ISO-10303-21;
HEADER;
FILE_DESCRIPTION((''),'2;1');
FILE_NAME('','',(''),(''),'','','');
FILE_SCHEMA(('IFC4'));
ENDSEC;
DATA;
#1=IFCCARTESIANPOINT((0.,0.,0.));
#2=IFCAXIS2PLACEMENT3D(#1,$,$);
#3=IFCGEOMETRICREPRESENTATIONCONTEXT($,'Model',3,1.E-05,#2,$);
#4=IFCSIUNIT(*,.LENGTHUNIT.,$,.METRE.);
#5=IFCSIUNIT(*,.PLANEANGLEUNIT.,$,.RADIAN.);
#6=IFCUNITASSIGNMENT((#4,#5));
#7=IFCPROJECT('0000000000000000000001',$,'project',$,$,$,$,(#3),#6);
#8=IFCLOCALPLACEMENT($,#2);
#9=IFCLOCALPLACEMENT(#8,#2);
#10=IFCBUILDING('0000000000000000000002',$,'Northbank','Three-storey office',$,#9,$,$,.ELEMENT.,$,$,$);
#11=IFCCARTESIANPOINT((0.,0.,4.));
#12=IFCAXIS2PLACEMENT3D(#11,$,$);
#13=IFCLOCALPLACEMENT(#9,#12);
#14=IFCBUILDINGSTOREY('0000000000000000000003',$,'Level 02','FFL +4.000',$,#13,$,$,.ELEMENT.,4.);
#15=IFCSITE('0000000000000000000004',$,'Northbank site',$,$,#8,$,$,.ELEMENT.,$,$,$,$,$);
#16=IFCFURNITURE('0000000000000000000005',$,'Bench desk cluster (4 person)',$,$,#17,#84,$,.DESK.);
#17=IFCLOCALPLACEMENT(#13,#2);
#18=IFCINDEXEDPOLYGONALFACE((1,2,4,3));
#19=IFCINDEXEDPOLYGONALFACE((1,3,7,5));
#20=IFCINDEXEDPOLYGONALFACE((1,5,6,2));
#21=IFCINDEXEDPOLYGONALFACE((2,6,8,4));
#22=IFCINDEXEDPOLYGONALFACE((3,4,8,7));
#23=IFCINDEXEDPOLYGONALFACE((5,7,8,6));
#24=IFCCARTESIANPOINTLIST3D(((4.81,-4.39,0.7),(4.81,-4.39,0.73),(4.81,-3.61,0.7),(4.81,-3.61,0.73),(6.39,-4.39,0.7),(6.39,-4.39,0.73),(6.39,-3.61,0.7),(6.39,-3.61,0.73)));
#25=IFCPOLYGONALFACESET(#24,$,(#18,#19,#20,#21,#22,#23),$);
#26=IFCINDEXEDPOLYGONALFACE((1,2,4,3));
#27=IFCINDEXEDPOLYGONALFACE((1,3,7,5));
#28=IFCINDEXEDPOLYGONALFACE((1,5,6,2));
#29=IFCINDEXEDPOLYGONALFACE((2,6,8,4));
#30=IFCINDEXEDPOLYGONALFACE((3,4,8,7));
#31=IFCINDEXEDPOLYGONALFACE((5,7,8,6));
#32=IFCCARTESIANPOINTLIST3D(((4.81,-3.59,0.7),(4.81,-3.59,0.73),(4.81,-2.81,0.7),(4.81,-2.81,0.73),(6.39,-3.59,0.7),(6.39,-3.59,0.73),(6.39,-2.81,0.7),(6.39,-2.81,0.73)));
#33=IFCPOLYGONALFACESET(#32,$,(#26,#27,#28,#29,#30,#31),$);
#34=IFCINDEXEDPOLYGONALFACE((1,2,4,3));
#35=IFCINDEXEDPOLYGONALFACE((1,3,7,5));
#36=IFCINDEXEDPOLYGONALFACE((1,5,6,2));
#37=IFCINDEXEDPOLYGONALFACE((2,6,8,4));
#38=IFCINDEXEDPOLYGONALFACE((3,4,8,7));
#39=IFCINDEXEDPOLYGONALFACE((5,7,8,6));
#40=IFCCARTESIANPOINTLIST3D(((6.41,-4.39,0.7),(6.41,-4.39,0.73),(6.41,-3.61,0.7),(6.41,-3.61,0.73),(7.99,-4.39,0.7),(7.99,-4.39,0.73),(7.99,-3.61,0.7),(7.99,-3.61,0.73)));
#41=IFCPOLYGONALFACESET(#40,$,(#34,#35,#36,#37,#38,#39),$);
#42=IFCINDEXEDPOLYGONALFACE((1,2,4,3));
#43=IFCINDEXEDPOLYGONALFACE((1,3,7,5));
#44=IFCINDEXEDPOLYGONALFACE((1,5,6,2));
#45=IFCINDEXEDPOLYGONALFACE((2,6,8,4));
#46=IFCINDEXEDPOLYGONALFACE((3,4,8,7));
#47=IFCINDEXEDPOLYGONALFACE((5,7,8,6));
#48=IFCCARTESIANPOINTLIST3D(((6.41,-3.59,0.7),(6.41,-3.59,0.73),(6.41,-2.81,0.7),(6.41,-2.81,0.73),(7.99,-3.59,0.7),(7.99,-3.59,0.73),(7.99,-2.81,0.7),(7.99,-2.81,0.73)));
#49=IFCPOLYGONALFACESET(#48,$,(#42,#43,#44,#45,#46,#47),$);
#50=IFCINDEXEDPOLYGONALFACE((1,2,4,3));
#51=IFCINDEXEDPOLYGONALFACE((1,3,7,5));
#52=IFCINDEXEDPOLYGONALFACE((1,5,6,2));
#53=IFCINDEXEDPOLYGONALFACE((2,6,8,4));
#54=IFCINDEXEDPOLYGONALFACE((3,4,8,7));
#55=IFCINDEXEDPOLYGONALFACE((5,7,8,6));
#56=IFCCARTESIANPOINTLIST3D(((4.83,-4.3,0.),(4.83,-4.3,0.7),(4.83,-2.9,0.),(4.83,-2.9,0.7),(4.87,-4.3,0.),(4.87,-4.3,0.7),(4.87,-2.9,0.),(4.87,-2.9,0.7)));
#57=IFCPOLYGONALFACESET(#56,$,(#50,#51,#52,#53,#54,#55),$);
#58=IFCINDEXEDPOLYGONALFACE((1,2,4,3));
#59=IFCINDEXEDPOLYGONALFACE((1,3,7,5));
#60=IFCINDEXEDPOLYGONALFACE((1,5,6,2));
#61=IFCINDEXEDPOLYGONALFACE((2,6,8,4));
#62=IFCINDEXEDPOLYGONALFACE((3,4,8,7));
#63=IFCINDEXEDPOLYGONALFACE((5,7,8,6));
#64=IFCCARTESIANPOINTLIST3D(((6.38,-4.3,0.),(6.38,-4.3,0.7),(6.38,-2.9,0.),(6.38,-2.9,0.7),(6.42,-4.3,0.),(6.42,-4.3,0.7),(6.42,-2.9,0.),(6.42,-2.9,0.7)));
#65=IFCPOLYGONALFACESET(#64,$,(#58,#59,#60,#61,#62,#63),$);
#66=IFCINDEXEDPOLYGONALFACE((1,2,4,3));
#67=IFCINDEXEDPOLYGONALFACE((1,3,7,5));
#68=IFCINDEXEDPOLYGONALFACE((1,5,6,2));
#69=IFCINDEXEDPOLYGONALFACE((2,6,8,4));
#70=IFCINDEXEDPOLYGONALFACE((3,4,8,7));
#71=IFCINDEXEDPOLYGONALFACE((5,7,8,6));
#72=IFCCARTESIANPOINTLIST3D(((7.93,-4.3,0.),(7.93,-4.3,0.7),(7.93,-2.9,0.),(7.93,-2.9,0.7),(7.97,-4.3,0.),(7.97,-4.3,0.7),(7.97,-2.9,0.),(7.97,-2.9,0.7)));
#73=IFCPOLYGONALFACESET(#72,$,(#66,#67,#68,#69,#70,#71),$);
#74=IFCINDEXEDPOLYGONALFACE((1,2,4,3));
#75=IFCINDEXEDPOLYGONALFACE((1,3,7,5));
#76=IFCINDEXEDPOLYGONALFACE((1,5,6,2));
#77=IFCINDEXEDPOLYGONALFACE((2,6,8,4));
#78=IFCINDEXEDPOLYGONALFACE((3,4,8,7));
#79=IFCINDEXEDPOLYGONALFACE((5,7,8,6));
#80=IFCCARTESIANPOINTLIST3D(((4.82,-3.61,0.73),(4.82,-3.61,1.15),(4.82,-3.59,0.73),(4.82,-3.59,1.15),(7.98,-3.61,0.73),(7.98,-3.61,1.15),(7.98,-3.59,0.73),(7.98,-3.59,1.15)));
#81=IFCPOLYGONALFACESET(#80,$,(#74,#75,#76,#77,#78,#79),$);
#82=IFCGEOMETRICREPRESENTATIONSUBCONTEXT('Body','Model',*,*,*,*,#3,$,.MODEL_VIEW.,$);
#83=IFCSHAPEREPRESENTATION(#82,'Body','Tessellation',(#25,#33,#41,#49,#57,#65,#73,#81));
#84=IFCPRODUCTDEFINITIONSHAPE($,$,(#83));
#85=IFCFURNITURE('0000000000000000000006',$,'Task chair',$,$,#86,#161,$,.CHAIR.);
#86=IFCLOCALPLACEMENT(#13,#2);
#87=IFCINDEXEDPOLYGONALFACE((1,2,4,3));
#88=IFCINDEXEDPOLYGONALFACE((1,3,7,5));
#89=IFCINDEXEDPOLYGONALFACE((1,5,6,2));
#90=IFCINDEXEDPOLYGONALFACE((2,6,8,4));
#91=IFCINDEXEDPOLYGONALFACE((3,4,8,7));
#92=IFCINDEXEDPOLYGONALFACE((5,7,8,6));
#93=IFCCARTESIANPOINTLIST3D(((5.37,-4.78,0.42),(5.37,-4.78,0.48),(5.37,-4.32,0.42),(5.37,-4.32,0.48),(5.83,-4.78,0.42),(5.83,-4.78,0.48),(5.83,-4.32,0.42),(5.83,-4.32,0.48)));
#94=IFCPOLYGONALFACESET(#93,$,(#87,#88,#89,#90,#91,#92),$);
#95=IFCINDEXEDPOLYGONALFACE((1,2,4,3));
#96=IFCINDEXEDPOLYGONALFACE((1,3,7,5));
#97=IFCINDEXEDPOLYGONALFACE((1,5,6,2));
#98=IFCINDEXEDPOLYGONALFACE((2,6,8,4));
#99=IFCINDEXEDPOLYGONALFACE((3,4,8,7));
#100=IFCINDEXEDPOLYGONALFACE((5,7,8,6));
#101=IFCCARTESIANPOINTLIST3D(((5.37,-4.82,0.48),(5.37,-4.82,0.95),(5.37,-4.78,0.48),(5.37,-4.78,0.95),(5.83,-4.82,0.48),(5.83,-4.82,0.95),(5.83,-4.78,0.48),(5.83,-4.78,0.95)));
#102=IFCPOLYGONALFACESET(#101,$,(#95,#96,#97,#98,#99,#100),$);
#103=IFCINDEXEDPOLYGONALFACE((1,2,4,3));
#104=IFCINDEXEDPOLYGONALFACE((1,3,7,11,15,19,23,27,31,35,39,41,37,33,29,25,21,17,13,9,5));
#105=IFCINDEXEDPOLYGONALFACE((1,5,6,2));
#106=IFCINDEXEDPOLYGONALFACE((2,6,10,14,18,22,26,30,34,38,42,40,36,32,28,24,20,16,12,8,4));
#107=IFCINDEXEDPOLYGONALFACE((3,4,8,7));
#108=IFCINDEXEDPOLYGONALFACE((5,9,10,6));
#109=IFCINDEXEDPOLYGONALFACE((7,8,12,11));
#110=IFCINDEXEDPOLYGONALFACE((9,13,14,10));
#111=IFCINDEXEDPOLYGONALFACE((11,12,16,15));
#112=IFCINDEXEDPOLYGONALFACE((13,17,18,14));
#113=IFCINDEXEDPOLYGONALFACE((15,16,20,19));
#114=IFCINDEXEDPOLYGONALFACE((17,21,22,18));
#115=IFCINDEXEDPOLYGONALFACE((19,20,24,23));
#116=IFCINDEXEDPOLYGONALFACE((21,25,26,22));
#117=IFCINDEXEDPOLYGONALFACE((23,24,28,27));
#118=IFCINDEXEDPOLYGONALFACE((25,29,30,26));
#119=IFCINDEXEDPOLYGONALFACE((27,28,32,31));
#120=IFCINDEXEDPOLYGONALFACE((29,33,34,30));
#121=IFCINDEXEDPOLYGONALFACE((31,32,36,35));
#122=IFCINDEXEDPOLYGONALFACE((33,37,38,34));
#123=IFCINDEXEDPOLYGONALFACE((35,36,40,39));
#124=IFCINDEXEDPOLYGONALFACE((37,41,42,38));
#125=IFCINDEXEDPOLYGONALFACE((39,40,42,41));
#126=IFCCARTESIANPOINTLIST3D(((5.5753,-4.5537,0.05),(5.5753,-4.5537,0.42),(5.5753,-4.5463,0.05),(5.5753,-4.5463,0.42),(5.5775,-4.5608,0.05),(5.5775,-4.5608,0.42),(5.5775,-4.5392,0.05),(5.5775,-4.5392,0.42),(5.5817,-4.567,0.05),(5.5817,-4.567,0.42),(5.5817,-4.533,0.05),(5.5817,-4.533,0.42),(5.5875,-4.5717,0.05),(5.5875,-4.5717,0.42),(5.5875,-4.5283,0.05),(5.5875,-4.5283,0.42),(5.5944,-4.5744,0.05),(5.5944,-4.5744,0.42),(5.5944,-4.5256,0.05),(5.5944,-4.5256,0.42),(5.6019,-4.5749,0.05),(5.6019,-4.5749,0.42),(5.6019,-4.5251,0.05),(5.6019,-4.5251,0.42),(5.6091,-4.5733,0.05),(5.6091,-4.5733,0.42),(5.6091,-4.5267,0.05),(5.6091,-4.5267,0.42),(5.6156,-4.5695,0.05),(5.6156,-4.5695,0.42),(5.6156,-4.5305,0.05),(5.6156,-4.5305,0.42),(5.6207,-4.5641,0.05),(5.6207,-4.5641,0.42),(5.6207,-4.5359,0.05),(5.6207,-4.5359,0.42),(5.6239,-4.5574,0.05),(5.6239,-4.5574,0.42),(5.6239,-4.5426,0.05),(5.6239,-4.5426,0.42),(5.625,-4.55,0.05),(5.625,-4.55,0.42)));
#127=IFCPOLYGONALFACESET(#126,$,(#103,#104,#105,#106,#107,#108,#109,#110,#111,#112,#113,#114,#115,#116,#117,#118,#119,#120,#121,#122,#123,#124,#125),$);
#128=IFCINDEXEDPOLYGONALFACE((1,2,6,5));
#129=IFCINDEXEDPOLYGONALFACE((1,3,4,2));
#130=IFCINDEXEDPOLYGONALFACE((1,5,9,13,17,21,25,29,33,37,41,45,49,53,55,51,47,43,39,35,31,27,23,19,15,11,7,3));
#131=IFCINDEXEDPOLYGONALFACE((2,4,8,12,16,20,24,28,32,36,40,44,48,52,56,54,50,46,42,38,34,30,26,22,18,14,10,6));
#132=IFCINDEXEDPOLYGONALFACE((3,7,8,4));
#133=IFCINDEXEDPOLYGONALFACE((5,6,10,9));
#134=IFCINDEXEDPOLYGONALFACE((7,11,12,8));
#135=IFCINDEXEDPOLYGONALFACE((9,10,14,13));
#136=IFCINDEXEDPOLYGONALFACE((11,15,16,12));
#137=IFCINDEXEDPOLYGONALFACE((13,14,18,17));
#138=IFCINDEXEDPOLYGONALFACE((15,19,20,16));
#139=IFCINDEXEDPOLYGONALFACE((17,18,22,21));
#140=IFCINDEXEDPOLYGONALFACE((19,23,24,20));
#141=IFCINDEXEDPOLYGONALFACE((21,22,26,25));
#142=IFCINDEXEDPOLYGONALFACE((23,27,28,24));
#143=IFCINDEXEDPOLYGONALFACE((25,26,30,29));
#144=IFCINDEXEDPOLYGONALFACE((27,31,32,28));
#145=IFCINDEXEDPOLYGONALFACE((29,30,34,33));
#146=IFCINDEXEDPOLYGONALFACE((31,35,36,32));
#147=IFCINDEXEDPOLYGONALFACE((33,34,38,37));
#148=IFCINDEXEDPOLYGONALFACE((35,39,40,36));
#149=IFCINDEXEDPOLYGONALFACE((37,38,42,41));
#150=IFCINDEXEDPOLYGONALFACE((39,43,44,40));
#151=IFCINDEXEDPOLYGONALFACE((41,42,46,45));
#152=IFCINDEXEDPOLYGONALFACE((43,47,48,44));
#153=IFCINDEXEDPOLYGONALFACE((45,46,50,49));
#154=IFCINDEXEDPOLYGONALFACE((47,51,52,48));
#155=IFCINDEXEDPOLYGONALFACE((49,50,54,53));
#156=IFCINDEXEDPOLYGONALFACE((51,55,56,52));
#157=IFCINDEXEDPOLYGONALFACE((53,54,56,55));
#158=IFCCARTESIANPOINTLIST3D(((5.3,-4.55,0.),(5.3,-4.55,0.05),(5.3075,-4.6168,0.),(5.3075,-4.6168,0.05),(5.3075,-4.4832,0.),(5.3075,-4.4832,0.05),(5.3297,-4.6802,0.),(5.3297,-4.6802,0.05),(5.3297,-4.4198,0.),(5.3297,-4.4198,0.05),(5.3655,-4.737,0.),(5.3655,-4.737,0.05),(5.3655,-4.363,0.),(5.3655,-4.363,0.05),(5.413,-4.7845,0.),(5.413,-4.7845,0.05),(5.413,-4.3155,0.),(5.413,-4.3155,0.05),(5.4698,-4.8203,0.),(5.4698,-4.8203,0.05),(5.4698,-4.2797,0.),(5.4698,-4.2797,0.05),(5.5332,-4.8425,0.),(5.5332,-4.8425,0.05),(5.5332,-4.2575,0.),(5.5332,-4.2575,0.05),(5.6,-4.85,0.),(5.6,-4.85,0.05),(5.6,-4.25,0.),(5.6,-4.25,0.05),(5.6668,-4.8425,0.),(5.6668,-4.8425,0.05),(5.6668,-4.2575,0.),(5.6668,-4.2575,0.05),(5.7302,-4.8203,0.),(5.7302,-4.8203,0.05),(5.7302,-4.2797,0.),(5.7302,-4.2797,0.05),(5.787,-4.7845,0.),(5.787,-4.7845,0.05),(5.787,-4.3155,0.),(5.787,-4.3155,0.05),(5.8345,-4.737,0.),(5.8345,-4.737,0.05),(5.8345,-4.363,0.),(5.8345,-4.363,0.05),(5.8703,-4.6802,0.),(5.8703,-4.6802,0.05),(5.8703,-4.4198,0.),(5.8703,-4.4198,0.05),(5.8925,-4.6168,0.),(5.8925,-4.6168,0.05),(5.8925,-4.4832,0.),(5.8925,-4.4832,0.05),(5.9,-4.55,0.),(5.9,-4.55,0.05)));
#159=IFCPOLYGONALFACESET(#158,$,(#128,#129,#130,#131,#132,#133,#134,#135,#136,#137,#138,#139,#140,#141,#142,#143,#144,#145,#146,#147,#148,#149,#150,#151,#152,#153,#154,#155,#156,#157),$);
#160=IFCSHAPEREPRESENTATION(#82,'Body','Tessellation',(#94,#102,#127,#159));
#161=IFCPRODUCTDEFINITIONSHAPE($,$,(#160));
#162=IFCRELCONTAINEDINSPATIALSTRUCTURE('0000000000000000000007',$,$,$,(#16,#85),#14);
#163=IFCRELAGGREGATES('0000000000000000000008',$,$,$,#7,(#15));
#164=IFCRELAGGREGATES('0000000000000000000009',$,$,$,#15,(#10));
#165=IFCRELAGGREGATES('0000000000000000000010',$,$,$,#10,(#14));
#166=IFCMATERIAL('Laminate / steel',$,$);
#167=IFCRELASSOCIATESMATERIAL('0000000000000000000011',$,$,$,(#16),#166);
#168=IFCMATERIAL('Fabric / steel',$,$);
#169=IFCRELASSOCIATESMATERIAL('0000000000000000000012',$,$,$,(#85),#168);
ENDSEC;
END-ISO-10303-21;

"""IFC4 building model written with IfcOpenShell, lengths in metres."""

from ifc_helpers import new_model, si_unit, frame, origin, place, context, subcontext, project, spatial, rectangle, circle, extrude, material, element, save


model = new_model("IFC4")

# Units and contexts
model_context = context("Model", 3, precision=1e-05, world=origin())
body_context = subcontext(model_context, "Body", "Model", "MODEL_VIEW")
ifc_project = project(units=[si_unit("LENGTHUNIT", "METRE"), si_unit("PLANEANGLEUNIT", "RADIAN")], contexts=[model_context])

# Site, building, storey
site_placement = place(None, origin())
site = spatial("IfcSite", under=ifc_project, at=site_placement, Name="Northbank site", CompositionType="ELEMENT")
building_placement = place(site_placement, origin())
building = spatial("IfcBuilding", under=site, at=building_placement, Name="Northbank", Description="Three-storey office", CompositionType="ELEMENT")
storey_placement = place(building_placement, frame((0.0, 0.0, 4.0)))
storey = spatial("IfcBuildingStorey", under=building, at=storey_placement, Name="Level 02", Description="FFL +4.000", CompositionType="ELEMENT", Elevation=4.0)

# Furniture
ifc_material_1 = material(Name="Fabric / steel")
ifc_material_2 = material(Name="Laminate / steel")
furniture_1_placement = place(storey_placement, frame((0.0, 0.0, -4.0)))
element("IfcFurniture", 1, at=furniture_1_placement, inside=storey, material=ifc_material_2, Name="Bench desk cluster (4 person)", PredefinedType="DESK", context=body_context, shape_type="SweptSolid", body=[
    extrude(rectangle(XDim=1.58, YDim=0.78), frame((5.6, -4.0, 4.7)), (0.0, 0.0, 1.0), 0.03),
    extrude(rectangle(XDim=1.58, YDim=0.78), frame((5.6, -3.2, 4.7)), (0.0, 0.0, 1.0), 0.03),
    extrude(rectangle(XDim=1.58, YDim=0.78), frame((7.2, -4.0, 4.7)), (0.0, 0.0, 1.0), 0.03),
    extrude(rectangle(XDim=1.58, YDim=0.78), frame((7.2, -3.2, 4.7)), (0.0, 0.0, 1.0), 0.03),
    extrude(rectangle(XDim=0.04, YDim=1.4), frame((4.85, -3.6, 4.0)), (0.0, 0.0, 1.0), 0.7),
    extrude(rectangle(XDim=0.04, YDim=1.4), frame((6.4, -3.6, 4.0)), (0.0, 0.0, 1.0), 0.7),
    extrude(rectangle(XDim=0.04, YDim=1.4), frame((7.95, -3.6, 4.0)), (0.0, 0.0, 1.0), 0.7),
    extrude(rectangle(XDim=3.16, YDim=0.02), frame((6.4, -3.6, 4.73)), (0.0, 0.0, 1.0), 0.42),
])
furniture_2_placement = place(storey_placement, frame((0.0, 0.0, -4.0)))
element("IfcFurniture", 2, at=furniture_2_placement, inside=storey, material=ifc_material_1, Name="Task chair", PredefinedType="CHAIR", context=body_context, shape_type="SweptSolid", body=[
    extrude(rectangle(XDim=0.46, YDim=0.46), frame((5.6, -4.55, 4.42)), (0.0, 0.0, 1.0), 0.06),
    extrude(rectangle(XDim=0.46, YDim=0.04), frame((5.6, -4.8, 4.48)), (0.0, 0.0, 1.0), 0.47),
    extrude(circle(Radius=0.025), frame((5.6, -4.55, 4.05), z_axis=(0.0, 0.0, 1.0), x_axis=(1.0, 0.0, 0.0)), (0.0, 0.0, 1.0), 0.37),
    extrude(circle(Radius=0.3), frame((5.6, -4.55, 4.0), z_axis=(0.0, 0.0, 1.0), x_axis=(1.0, 0.0, 0.0)), (0.0, 0.0, 1.0), 0.05),
])

save(model, "model.ifc")
